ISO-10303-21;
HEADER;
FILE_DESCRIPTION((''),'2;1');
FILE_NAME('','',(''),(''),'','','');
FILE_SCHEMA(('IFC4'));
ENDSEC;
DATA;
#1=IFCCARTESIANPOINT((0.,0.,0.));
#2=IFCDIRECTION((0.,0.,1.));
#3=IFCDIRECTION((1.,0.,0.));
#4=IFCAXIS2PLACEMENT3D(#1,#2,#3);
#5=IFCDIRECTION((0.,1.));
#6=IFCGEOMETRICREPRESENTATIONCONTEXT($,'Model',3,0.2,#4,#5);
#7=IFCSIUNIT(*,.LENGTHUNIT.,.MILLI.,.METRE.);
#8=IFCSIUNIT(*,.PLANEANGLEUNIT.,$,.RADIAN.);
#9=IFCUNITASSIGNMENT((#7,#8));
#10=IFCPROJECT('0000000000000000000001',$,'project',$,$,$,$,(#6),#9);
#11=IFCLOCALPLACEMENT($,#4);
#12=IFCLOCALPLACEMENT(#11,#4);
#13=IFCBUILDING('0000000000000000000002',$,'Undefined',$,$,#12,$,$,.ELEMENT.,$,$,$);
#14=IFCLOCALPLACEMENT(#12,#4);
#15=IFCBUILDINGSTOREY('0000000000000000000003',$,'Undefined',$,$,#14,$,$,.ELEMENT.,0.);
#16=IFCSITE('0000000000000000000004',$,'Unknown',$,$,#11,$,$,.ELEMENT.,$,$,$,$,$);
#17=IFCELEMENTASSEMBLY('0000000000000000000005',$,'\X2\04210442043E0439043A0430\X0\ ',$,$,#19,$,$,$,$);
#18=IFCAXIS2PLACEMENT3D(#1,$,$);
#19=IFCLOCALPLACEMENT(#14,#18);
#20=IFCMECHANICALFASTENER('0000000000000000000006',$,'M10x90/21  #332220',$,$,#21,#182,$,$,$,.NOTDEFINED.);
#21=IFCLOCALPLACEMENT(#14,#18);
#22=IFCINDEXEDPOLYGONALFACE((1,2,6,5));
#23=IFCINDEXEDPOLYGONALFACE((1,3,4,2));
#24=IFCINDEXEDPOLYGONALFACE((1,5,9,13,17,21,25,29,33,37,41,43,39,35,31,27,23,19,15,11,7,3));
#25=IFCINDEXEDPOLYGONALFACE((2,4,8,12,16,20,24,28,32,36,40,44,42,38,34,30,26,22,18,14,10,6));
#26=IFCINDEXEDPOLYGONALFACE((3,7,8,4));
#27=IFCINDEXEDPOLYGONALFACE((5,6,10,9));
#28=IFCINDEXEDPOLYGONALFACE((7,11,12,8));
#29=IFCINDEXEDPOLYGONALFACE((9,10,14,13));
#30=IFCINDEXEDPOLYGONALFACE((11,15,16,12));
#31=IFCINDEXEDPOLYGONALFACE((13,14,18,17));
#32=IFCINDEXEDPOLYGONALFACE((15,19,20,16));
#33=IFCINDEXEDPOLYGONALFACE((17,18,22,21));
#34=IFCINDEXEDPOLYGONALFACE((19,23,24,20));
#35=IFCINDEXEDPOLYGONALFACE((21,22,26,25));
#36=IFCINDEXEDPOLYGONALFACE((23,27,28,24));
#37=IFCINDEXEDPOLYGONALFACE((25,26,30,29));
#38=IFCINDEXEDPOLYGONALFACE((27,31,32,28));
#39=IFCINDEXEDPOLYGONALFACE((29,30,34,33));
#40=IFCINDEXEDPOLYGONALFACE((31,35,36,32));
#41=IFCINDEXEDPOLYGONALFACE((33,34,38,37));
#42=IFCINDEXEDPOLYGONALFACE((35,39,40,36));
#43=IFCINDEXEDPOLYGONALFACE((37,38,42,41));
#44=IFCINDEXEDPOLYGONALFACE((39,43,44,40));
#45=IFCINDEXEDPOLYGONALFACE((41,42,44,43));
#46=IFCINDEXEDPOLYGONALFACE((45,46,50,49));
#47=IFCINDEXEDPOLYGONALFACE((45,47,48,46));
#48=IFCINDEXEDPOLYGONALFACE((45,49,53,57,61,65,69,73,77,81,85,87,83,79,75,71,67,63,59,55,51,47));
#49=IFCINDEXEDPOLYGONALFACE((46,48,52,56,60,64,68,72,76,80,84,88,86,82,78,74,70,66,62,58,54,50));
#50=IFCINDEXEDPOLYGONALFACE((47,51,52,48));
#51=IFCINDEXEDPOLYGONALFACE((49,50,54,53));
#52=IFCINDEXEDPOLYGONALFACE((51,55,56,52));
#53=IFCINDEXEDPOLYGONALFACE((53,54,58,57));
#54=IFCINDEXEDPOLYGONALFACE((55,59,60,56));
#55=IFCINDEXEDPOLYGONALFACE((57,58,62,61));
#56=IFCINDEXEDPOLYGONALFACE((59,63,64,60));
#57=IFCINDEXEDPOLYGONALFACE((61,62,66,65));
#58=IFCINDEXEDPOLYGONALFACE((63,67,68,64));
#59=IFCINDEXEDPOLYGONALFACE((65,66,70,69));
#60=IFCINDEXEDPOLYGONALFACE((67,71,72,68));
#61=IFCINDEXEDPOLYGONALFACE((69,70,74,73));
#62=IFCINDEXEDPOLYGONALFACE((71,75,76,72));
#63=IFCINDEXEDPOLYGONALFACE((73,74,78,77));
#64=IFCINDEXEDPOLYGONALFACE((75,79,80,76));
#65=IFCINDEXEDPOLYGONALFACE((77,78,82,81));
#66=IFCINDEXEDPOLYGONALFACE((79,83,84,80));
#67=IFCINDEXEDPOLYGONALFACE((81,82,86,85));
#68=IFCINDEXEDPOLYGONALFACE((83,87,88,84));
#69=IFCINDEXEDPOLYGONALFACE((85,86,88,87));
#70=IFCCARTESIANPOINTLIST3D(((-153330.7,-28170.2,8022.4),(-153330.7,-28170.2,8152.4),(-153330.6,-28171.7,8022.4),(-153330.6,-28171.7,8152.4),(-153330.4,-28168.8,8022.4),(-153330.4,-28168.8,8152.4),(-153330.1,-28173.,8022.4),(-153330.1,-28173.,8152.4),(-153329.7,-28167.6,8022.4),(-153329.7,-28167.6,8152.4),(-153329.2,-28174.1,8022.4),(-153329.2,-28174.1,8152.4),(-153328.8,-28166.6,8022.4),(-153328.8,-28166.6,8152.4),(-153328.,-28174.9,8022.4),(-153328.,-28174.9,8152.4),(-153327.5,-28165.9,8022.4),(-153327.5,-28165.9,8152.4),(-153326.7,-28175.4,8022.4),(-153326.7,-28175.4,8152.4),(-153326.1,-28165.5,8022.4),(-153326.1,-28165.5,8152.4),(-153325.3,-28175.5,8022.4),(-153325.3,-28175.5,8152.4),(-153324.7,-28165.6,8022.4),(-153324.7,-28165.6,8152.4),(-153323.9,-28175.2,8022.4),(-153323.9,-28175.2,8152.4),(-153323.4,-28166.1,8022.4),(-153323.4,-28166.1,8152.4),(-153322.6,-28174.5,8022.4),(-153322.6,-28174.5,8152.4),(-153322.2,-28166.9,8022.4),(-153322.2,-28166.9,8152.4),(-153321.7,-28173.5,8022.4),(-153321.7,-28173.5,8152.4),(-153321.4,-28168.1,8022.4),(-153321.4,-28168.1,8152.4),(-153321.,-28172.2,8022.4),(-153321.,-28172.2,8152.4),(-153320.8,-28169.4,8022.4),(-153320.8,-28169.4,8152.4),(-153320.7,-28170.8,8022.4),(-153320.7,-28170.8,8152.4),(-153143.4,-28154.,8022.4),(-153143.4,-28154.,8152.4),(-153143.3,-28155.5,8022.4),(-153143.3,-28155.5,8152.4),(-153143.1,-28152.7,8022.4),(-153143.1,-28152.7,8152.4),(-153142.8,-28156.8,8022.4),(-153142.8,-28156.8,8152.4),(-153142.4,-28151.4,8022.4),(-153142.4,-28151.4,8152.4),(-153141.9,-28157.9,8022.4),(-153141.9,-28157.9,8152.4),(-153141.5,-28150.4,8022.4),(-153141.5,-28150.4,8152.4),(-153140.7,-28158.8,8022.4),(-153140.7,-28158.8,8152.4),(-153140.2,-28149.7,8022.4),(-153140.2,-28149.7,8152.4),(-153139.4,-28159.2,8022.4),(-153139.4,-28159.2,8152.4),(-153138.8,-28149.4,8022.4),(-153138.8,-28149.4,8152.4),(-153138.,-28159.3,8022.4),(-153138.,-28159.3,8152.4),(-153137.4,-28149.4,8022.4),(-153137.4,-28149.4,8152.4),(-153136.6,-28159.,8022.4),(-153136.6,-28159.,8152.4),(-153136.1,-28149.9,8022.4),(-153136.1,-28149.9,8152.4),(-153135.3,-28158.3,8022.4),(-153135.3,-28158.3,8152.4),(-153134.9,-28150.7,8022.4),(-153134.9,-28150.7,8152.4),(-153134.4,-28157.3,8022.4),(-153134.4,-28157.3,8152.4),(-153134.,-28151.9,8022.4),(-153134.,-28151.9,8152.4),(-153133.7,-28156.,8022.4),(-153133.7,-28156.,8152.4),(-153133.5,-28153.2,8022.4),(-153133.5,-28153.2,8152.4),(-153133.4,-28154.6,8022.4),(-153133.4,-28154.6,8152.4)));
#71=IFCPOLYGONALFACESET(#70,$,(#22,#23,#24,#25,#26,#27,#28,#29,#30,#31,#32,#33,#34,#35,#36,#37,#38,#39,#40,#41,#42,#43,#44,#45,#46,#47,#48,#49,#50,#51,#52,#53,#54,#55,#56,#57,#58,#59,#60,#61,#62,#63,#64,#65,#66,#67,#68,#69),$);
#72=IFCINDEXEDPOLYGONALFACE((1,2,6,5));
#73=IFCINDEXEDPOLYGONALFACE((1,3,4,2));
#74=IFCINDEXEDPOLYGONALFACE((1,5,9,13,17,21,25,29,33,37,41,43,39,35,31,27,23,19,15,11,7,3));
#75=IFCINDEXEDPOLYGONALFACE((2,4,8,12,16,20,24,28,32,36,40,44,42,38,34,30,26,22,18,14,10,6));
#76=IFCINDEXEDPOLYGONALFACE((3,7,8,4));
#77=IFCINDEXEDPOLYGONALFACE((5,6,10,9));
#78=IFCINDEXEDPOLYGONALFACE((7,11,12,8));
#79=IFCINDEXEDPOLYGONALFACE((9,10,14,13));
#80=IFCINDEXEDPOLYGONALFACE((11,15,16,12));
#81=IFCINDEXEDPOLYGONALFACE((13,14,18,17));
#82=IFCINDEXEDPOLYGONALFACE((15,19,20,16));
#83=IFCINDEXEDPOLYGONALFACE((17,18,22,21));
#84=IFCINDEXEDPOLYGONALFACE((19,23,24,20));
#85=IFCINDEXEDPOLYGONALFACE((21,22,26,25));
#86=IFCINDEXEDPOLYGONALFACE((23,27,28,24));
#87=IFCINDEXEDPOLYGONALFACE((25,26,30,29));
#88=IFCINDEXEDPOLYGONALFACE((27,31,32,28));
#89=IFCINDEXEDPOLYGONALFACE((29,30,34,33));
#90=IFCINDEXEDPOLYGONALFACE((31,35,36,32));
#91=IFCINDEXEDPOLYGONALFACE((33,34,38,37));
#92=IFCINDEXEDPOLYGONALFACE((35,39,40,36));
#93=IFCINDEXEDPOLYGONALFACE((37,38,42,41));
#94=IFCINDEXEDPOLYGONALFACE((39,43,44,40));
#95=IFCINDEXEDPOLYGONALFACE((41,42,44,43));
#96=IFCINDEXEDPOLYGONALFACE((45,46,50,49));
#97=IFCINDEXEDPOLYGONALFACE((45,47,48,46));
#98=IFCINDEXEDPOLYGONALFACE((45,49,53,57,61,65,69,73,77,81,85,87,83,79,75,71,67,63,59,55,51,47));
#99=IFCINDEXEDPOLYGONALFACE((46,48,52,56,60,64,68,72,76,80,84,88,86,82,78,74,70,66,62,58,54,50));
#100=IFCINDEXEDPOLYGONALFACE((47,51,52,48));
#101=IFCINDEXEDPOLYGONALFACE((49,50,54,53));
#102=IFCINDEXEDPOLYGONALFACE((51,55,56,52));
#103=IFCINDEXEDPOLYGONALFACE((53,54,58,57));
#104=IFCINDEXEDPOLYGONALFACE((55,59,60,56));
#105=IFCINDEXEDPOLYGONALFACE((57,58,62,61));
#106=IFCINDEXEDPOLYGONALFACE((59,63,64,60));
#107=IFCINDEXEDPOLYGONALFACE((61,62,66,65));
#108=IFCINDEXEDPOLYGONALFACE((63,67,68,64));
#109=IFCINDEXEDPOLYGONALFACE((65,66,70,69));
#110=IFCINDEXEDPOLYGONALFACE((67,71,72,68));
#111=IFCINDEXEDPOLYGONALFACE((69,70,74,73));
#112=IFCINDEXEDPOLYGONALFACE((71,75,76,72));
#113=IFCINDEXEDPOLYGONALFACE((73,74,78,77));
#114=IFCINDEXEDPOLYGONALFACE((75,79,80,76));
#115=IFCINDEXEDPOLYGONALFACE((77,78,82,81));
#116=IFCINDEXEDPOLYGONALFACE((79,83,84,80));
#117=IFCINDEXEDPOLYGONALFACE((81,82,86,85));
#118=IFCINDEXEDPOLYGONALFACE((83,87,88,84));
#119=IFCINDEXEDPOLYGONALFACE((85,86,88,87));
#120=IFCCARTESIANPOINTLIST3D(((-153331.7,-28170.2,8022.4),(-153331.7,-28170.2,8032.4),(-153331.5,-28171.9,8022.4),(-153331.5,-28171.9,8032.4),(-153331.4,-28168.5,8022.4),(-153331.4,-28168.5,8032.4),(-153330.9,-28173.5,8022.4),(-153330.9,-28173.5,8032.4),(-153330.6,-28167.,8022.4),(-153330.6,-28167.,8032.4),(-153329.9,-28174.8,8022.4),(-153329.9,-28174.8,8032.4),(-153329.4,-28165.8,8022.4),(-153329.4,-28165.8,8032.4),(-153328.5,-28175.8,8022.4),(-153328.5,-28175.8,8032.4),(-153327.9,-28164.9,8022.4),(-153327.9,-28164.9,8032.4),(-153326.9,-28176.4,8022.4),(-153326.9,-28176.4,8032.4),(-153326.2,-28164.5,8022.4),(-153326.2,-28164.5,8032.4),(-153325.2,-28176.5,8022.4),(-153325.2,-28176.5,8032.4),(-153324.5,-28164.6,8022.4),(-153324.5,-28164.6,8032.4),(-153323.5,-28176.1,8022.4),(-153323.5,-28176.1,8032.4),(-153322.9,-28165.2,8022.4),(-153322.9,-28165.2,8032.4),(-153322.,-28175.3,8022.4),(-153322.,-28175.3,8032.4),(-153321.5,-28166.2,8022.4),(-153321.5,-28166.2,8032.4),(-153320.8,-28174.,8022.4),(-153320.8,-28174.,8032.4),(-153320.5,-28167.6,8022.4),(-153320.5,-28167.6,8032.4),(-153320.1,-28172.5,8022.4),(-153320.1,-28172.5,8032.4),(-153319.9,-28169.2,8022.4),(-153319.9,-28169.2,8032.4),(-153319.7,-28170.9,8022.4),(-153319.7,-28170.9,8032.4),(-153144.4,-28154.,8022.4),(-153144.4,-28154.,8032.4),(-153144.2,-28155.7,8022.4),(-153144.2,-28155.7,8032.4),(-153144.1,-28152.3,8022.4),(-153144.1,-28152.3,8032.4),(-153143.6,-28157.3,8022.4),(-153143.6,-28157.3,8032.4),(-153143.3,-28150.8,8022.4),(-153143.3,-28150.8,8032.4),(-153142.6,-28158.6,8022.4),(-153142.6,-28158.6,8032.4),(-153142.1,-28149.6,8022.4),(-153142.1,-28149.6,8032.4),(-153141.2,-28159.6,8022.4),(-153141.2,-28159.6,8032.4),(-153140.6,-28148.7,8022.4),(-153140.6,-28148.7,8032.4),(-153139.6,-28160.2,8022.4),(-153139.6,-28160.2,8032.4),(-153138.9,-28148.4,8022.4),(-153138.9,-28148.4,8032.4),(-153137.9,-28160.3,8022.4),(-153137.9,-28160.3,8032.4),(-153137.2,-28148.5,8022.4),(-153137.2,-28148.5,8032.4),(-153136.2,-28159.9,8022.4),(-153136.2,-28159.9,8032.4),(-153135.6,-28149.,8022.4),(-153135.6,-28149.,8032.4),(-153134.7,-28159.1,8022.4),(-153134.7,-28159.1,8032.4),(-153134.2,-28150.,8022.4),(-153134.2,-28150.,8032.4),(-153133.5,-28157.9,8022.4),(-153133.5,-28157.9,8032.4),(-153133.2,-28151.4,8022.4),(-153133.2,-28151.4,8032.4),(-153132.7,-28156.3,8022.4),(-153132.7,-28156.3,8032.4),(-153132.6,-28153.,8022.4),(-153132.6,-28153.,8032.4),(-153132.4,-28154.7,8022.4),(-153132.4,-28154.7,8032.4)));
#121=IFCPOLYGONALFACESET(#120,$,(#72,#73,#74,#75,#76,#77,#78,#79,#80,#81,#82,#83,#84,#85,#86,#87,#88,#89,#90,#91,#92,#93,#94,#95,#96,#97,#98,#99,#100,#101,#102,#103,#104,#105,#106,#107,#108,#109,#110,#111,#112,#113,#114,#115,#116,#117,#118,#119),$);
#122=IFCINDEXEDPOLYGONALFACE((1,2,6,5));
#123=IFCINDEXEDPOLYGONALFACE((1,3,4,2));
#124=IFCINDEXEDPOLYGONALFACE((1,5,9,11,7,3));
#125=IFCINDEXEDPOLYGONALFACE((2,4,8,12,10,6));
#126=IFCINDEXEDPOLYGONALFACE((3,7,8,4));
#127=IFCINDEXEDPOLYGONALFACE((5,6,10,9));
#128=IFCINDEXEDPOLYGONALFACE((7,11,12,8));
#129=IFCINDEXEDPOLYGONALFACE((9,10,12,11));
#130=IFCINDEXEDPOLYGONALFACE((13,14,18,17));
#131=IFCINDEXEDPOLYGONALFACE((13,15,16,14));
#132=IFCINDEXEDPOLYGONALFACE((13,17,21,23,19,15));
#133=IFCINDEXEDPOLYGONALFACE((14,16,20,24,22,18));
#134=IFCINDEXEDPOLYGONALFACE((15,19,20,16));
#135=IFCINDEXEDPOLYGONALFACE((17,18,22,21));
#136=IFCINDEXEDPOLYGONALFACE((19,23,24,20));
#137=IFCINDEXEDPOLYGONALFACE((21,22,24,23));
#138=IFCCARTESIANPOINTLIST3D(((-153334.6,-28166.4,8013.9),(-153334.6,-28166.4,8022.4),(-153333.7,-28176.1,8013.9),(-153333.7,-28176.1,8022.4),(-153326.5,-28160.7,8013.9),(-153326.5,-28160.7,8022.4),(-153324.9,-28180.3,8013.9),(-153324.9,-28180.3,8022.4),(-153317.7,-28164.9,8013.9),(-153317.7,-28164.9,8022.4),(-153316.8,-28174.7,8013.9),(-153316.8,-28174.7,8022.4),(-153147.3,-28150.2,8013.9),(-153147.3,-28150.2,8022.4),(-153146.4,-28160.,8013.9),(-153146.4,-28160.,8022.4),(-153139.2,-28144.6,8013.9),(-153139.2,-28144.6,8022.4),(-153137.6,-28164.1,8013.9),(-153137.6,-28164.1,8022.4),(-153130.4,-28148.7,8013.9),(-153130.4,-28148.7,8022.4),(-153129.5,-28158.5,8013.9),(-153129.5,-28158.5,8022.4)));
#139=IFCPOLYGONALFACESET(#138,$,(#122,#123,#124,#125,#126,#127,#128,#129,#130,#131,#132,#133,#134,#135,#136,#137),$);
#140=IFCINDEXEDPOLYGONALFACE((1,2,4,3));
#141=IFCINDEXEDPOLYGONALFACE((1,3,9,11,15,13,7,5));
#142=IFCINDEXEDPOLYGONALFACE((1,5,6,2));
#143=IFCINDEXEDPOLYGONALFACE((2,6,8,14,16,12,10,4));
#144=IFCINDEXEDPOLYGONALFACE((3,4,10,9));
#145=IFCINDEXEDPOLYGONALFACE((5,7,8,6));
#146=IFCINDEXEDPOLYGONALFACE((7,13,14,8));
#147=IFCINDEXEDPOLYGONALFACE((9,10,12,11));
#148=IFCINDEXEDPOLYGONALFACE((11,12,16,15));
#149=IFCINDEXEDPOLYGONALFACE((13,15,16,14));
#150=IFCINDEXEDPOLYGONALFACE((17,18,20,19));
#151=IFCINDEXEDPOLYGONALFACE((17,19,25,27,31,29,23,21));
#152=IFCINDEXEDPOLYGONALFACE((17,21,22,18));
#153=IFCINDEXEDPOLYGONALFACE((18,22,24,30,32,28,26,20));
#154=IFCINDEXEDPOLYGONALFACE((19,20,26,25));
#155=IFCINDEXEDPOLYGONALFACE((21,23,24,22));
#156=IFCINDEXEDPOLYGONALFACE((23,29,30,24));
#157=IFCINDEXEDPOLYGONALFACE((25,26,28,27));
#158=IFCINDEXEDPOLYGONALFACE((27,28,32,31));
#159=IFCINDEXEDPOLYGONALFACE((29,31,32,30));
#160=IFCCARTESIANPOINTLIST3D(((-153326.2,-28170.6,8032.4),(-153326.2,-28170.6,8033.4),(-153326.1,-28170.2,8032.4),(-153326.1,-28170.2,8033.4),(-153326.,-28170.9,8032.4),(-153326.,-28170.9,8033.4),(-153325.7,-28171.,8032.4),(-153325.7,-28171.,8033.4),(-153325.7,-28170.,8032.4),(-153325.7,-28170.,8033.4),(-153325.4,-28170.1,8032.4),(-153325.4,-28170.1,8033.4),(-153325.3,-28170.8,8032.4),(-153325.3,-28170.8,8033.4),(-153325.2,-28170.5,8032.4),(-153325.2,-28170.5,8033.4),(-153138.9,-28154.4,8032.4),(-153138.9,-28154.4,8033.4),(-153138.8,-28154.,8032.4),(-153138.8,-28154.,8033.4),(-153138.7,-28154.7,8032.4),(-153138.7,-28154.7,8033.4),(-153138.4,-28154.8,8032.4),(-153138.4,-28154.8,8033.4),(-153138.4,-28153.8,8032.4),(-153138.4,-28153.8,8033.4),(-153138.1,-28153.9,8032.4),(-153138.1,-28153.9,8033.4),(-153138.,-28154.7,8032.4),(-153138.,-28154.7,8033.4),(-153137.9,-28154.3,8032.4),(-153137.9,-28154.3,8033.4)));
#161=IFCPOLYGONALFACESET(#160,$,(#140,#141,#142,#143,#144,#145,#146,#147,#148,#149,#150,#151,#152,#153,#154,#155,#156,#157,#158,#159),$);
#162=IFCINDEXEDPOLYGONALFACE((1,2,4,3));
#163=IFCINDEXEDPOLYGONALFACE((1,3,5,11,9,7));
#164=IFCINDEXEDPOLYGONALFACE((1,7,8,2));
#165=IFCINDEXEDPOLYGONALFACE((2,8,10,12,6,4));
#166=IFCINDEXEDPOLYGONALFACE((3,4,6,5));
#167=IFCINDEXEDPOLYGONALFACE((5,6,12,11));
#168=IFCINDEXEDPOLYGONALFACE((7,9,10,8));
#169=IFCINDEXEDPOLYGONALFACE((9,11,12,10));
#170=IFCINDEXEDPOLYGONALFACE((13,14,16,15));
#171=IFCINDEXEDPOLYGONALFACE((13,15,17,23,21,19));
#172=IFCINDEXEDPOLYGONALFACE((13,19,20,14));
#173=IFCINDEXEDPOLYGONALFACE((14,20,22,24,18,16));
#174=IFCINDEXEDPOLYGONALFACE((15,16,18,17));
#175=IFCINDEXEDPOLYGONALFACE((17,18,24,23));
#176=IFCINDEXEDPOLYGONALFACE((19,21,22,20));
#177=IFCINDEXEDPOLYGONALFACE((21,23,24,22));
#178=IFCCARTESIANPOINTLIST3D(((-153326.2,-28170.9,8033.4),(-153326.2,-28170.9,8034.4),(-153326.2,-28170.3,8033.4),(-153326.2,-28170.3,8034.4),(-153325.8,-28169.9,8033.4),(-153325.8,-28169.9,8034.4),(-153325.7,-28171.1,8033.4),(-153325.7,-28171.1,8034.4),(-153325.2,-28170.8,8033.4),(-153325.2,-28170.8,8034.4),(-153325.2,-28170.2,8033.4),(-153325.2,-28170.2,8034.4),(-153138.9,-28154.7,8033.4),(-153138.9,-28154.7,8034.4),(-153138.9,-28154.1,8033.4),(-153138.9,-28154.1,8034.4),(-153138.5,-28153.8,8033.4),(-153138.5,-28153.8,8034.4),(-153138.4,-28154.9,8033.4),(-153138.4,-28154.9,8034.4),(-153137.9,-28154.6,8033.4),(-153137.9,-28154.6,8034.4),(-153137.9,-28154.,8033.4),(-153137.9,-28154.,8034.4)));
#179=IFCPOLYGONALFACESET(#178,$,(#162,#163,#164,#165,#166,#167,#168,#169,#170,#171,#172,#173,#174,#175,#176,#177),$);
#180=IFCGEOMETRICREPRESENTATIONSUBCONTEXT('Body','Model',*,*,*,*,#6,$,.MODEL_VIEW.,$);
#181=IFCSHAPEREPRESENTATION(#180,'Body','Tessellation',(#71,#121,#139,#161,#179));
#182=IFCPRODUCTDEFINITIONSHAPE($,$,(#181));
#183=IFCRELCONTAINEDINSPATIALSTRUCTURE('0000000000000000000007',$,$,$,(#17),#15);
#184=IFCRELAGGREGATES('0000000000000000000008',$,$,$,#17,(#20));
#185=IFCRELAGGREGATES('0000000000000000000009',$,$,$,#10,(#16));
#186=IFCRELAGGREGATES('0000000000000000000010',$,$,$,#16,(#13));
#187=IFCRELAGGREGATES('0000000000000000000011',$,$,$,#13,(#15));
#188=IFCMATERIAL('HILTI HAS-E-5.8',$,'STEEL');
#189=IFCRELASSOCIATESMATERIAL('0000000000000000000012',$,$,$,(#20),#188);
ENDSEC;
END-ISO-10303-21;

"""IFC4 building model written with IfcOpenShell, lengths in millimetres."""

from ifc_helpers import new_model, si_unit, direction, frame, origin_with_axes, place, context, subcontext, project, spatial, line, arc, indexed_curve, outline, extrude, source, transform, mapped, material, element, aggregate, save


model = new_model("IFC4")

# Units and contexts
model_context = context("Model", 3, precision=0.2, world=origin_with_axes(), true_north=direction((0.0, 1.0)))
body_context = subcontext(model_context, "Body", "Model", "MODEL_VIEW")
ifc_project = project(units=[si_unit("LENGTHUNIT", "METRE", prefix="MILLI"), si_unit("PLANEANGLEUNIT", "RADIAN")], contexts=[model_context])

# Site, building, storey
site_placement = place(None, origin_with_axes())
site = spatial("IfcSite", under=ifc_project, at=site_placement, Name="Unknown", CompositionType="ELEMENT")
building_placement = place(site_placement, origin_with_axes())
building = spatial("IfcBuilding", under=site, at=building_placement, Name="Undefined", CompositionType="ELEMENT")
storey_placement = place(building_placement, origin_with_axes())
storey = spatial("IfcBuildingStorey", under=building, at=storey_placement, Name="Undefined", CompositionType="ELEMENT", Elevation=0.0)

# Element assembly
assembly_1_placement = place(storey_placement, frame((-153232.0, -28162.4, 4934.6), z_axis=(-0.086114, 0.996285, 0.0), x_axis=(0.0, 0.0, 1.0)))
assembly_1 = element("IfcElementAssembly", 1, at=assembly_1_placement, inside=storey, Name="Стойка ")

# Mechanical fastener
ifc_material_1 = material(Name="HILTI HAS-E-5.8", Category="STEEL")
shared_shape_1 = source(origin_with_axes(), body_context, "Body", "SweptSolid", [
    extrude(outline(indexed_curve([(5.0, 0.0), (0.0, 5.0), (-5.0, 0.0), (0.0, -5.0)], segments=[arc(1, 2, 3), arc(3, 4, 1)])), frame((0.0, 0.0, 0.0), z_axis=(0.0, 0.0, -1.0), x_axis=(0.0, 1.0, 0.0)), (0.0, 0.0, 1.0), 130.0),
    extrude(outline(indexed_curve([(6.0, 0.0), (0.0, 6.0), (-6.0, 0.0), (0.0, -6.0)], segments=[arc(1, 2, 3), arc(3, 4, 1)])), frame((0.0, 0.0, 0.0), z_axis=(0.0, 0.0, -1.0), x_axis=(0.0, 1.0, 0.0)), (0.0, 0.0, 1.0), 10.0),
    extrude(outline(indexed_curve([(9.8, 0.0), (4.9, 8.5), (-4.9, 8.5), (-9.8, 0.0), (-4.9, -8.5), (4.9, -8.5)], segments=[line(1, 2, 3, 4, 5, 6, 1)])), frame((0.0, 0.0, 8.5), z_axis=(0.0, 0.0, -1.0), x_axis=(0.0, 1.0, 0.0)), (0.0, 0.0, 1.0), 8.5),
    extrude(outline(indexed_curve([(0.5, 0.0), (0.0, 0.5), (-0.5, 0.0), (0.0, -0.5)], segments=[arc(1, 2, 3), arc(3, 4, 1)])), frame((0.0, 0.0, -10.0), z_axis=(0.0, 0.0, -1.0), x_axis=(0.0, 1.0, 0.0)), (0.0, 0.0, 1.0), 1.0),
    extrude(outline(indexed_curve([(0.6, 0.0), (0.3, 0.5), (-0.3, 0.5), (-0.6, 0.0), (-0.3, -0.5), (0.3, -0.5)], segments=[line(1, 2, 3, 4, 5, 6, 1)])), frame((0.0, 0.0, -11.0), z_axis=(0.0, 0.0, -1.0), x_axis=(0.0, 1.0, 0.0)), (0.0, 0.0, 1.0), 1.0),
])
mechanical_fastener_1_placement = place(assembly_1_placement, frame((3087.9, -94.0, 0.0), z_axis=(-1.0, 0.0, 0.0), x_axis=(0.0, 1.0, 0.0)))
mechanical_fastener_1 = element("IfcMechanicalFastener", 2, at=mechanical_fastener_1_placement, material=ifc_material_1, Name="M10x90/21  #332220", PredefinedType="NOTDEFINED", context=body_context, shape_type="MappedRepresentation", body=[
    mapped(shared_shape_1, transform((0.0, 0.0, 0.0))),
    mapped(shared_shape_1, transform((188.0, 0.0, 0.0))),
])
aggregate(assembly_1, [mechanical_fastener_1])

save(model, "model.ifc")
